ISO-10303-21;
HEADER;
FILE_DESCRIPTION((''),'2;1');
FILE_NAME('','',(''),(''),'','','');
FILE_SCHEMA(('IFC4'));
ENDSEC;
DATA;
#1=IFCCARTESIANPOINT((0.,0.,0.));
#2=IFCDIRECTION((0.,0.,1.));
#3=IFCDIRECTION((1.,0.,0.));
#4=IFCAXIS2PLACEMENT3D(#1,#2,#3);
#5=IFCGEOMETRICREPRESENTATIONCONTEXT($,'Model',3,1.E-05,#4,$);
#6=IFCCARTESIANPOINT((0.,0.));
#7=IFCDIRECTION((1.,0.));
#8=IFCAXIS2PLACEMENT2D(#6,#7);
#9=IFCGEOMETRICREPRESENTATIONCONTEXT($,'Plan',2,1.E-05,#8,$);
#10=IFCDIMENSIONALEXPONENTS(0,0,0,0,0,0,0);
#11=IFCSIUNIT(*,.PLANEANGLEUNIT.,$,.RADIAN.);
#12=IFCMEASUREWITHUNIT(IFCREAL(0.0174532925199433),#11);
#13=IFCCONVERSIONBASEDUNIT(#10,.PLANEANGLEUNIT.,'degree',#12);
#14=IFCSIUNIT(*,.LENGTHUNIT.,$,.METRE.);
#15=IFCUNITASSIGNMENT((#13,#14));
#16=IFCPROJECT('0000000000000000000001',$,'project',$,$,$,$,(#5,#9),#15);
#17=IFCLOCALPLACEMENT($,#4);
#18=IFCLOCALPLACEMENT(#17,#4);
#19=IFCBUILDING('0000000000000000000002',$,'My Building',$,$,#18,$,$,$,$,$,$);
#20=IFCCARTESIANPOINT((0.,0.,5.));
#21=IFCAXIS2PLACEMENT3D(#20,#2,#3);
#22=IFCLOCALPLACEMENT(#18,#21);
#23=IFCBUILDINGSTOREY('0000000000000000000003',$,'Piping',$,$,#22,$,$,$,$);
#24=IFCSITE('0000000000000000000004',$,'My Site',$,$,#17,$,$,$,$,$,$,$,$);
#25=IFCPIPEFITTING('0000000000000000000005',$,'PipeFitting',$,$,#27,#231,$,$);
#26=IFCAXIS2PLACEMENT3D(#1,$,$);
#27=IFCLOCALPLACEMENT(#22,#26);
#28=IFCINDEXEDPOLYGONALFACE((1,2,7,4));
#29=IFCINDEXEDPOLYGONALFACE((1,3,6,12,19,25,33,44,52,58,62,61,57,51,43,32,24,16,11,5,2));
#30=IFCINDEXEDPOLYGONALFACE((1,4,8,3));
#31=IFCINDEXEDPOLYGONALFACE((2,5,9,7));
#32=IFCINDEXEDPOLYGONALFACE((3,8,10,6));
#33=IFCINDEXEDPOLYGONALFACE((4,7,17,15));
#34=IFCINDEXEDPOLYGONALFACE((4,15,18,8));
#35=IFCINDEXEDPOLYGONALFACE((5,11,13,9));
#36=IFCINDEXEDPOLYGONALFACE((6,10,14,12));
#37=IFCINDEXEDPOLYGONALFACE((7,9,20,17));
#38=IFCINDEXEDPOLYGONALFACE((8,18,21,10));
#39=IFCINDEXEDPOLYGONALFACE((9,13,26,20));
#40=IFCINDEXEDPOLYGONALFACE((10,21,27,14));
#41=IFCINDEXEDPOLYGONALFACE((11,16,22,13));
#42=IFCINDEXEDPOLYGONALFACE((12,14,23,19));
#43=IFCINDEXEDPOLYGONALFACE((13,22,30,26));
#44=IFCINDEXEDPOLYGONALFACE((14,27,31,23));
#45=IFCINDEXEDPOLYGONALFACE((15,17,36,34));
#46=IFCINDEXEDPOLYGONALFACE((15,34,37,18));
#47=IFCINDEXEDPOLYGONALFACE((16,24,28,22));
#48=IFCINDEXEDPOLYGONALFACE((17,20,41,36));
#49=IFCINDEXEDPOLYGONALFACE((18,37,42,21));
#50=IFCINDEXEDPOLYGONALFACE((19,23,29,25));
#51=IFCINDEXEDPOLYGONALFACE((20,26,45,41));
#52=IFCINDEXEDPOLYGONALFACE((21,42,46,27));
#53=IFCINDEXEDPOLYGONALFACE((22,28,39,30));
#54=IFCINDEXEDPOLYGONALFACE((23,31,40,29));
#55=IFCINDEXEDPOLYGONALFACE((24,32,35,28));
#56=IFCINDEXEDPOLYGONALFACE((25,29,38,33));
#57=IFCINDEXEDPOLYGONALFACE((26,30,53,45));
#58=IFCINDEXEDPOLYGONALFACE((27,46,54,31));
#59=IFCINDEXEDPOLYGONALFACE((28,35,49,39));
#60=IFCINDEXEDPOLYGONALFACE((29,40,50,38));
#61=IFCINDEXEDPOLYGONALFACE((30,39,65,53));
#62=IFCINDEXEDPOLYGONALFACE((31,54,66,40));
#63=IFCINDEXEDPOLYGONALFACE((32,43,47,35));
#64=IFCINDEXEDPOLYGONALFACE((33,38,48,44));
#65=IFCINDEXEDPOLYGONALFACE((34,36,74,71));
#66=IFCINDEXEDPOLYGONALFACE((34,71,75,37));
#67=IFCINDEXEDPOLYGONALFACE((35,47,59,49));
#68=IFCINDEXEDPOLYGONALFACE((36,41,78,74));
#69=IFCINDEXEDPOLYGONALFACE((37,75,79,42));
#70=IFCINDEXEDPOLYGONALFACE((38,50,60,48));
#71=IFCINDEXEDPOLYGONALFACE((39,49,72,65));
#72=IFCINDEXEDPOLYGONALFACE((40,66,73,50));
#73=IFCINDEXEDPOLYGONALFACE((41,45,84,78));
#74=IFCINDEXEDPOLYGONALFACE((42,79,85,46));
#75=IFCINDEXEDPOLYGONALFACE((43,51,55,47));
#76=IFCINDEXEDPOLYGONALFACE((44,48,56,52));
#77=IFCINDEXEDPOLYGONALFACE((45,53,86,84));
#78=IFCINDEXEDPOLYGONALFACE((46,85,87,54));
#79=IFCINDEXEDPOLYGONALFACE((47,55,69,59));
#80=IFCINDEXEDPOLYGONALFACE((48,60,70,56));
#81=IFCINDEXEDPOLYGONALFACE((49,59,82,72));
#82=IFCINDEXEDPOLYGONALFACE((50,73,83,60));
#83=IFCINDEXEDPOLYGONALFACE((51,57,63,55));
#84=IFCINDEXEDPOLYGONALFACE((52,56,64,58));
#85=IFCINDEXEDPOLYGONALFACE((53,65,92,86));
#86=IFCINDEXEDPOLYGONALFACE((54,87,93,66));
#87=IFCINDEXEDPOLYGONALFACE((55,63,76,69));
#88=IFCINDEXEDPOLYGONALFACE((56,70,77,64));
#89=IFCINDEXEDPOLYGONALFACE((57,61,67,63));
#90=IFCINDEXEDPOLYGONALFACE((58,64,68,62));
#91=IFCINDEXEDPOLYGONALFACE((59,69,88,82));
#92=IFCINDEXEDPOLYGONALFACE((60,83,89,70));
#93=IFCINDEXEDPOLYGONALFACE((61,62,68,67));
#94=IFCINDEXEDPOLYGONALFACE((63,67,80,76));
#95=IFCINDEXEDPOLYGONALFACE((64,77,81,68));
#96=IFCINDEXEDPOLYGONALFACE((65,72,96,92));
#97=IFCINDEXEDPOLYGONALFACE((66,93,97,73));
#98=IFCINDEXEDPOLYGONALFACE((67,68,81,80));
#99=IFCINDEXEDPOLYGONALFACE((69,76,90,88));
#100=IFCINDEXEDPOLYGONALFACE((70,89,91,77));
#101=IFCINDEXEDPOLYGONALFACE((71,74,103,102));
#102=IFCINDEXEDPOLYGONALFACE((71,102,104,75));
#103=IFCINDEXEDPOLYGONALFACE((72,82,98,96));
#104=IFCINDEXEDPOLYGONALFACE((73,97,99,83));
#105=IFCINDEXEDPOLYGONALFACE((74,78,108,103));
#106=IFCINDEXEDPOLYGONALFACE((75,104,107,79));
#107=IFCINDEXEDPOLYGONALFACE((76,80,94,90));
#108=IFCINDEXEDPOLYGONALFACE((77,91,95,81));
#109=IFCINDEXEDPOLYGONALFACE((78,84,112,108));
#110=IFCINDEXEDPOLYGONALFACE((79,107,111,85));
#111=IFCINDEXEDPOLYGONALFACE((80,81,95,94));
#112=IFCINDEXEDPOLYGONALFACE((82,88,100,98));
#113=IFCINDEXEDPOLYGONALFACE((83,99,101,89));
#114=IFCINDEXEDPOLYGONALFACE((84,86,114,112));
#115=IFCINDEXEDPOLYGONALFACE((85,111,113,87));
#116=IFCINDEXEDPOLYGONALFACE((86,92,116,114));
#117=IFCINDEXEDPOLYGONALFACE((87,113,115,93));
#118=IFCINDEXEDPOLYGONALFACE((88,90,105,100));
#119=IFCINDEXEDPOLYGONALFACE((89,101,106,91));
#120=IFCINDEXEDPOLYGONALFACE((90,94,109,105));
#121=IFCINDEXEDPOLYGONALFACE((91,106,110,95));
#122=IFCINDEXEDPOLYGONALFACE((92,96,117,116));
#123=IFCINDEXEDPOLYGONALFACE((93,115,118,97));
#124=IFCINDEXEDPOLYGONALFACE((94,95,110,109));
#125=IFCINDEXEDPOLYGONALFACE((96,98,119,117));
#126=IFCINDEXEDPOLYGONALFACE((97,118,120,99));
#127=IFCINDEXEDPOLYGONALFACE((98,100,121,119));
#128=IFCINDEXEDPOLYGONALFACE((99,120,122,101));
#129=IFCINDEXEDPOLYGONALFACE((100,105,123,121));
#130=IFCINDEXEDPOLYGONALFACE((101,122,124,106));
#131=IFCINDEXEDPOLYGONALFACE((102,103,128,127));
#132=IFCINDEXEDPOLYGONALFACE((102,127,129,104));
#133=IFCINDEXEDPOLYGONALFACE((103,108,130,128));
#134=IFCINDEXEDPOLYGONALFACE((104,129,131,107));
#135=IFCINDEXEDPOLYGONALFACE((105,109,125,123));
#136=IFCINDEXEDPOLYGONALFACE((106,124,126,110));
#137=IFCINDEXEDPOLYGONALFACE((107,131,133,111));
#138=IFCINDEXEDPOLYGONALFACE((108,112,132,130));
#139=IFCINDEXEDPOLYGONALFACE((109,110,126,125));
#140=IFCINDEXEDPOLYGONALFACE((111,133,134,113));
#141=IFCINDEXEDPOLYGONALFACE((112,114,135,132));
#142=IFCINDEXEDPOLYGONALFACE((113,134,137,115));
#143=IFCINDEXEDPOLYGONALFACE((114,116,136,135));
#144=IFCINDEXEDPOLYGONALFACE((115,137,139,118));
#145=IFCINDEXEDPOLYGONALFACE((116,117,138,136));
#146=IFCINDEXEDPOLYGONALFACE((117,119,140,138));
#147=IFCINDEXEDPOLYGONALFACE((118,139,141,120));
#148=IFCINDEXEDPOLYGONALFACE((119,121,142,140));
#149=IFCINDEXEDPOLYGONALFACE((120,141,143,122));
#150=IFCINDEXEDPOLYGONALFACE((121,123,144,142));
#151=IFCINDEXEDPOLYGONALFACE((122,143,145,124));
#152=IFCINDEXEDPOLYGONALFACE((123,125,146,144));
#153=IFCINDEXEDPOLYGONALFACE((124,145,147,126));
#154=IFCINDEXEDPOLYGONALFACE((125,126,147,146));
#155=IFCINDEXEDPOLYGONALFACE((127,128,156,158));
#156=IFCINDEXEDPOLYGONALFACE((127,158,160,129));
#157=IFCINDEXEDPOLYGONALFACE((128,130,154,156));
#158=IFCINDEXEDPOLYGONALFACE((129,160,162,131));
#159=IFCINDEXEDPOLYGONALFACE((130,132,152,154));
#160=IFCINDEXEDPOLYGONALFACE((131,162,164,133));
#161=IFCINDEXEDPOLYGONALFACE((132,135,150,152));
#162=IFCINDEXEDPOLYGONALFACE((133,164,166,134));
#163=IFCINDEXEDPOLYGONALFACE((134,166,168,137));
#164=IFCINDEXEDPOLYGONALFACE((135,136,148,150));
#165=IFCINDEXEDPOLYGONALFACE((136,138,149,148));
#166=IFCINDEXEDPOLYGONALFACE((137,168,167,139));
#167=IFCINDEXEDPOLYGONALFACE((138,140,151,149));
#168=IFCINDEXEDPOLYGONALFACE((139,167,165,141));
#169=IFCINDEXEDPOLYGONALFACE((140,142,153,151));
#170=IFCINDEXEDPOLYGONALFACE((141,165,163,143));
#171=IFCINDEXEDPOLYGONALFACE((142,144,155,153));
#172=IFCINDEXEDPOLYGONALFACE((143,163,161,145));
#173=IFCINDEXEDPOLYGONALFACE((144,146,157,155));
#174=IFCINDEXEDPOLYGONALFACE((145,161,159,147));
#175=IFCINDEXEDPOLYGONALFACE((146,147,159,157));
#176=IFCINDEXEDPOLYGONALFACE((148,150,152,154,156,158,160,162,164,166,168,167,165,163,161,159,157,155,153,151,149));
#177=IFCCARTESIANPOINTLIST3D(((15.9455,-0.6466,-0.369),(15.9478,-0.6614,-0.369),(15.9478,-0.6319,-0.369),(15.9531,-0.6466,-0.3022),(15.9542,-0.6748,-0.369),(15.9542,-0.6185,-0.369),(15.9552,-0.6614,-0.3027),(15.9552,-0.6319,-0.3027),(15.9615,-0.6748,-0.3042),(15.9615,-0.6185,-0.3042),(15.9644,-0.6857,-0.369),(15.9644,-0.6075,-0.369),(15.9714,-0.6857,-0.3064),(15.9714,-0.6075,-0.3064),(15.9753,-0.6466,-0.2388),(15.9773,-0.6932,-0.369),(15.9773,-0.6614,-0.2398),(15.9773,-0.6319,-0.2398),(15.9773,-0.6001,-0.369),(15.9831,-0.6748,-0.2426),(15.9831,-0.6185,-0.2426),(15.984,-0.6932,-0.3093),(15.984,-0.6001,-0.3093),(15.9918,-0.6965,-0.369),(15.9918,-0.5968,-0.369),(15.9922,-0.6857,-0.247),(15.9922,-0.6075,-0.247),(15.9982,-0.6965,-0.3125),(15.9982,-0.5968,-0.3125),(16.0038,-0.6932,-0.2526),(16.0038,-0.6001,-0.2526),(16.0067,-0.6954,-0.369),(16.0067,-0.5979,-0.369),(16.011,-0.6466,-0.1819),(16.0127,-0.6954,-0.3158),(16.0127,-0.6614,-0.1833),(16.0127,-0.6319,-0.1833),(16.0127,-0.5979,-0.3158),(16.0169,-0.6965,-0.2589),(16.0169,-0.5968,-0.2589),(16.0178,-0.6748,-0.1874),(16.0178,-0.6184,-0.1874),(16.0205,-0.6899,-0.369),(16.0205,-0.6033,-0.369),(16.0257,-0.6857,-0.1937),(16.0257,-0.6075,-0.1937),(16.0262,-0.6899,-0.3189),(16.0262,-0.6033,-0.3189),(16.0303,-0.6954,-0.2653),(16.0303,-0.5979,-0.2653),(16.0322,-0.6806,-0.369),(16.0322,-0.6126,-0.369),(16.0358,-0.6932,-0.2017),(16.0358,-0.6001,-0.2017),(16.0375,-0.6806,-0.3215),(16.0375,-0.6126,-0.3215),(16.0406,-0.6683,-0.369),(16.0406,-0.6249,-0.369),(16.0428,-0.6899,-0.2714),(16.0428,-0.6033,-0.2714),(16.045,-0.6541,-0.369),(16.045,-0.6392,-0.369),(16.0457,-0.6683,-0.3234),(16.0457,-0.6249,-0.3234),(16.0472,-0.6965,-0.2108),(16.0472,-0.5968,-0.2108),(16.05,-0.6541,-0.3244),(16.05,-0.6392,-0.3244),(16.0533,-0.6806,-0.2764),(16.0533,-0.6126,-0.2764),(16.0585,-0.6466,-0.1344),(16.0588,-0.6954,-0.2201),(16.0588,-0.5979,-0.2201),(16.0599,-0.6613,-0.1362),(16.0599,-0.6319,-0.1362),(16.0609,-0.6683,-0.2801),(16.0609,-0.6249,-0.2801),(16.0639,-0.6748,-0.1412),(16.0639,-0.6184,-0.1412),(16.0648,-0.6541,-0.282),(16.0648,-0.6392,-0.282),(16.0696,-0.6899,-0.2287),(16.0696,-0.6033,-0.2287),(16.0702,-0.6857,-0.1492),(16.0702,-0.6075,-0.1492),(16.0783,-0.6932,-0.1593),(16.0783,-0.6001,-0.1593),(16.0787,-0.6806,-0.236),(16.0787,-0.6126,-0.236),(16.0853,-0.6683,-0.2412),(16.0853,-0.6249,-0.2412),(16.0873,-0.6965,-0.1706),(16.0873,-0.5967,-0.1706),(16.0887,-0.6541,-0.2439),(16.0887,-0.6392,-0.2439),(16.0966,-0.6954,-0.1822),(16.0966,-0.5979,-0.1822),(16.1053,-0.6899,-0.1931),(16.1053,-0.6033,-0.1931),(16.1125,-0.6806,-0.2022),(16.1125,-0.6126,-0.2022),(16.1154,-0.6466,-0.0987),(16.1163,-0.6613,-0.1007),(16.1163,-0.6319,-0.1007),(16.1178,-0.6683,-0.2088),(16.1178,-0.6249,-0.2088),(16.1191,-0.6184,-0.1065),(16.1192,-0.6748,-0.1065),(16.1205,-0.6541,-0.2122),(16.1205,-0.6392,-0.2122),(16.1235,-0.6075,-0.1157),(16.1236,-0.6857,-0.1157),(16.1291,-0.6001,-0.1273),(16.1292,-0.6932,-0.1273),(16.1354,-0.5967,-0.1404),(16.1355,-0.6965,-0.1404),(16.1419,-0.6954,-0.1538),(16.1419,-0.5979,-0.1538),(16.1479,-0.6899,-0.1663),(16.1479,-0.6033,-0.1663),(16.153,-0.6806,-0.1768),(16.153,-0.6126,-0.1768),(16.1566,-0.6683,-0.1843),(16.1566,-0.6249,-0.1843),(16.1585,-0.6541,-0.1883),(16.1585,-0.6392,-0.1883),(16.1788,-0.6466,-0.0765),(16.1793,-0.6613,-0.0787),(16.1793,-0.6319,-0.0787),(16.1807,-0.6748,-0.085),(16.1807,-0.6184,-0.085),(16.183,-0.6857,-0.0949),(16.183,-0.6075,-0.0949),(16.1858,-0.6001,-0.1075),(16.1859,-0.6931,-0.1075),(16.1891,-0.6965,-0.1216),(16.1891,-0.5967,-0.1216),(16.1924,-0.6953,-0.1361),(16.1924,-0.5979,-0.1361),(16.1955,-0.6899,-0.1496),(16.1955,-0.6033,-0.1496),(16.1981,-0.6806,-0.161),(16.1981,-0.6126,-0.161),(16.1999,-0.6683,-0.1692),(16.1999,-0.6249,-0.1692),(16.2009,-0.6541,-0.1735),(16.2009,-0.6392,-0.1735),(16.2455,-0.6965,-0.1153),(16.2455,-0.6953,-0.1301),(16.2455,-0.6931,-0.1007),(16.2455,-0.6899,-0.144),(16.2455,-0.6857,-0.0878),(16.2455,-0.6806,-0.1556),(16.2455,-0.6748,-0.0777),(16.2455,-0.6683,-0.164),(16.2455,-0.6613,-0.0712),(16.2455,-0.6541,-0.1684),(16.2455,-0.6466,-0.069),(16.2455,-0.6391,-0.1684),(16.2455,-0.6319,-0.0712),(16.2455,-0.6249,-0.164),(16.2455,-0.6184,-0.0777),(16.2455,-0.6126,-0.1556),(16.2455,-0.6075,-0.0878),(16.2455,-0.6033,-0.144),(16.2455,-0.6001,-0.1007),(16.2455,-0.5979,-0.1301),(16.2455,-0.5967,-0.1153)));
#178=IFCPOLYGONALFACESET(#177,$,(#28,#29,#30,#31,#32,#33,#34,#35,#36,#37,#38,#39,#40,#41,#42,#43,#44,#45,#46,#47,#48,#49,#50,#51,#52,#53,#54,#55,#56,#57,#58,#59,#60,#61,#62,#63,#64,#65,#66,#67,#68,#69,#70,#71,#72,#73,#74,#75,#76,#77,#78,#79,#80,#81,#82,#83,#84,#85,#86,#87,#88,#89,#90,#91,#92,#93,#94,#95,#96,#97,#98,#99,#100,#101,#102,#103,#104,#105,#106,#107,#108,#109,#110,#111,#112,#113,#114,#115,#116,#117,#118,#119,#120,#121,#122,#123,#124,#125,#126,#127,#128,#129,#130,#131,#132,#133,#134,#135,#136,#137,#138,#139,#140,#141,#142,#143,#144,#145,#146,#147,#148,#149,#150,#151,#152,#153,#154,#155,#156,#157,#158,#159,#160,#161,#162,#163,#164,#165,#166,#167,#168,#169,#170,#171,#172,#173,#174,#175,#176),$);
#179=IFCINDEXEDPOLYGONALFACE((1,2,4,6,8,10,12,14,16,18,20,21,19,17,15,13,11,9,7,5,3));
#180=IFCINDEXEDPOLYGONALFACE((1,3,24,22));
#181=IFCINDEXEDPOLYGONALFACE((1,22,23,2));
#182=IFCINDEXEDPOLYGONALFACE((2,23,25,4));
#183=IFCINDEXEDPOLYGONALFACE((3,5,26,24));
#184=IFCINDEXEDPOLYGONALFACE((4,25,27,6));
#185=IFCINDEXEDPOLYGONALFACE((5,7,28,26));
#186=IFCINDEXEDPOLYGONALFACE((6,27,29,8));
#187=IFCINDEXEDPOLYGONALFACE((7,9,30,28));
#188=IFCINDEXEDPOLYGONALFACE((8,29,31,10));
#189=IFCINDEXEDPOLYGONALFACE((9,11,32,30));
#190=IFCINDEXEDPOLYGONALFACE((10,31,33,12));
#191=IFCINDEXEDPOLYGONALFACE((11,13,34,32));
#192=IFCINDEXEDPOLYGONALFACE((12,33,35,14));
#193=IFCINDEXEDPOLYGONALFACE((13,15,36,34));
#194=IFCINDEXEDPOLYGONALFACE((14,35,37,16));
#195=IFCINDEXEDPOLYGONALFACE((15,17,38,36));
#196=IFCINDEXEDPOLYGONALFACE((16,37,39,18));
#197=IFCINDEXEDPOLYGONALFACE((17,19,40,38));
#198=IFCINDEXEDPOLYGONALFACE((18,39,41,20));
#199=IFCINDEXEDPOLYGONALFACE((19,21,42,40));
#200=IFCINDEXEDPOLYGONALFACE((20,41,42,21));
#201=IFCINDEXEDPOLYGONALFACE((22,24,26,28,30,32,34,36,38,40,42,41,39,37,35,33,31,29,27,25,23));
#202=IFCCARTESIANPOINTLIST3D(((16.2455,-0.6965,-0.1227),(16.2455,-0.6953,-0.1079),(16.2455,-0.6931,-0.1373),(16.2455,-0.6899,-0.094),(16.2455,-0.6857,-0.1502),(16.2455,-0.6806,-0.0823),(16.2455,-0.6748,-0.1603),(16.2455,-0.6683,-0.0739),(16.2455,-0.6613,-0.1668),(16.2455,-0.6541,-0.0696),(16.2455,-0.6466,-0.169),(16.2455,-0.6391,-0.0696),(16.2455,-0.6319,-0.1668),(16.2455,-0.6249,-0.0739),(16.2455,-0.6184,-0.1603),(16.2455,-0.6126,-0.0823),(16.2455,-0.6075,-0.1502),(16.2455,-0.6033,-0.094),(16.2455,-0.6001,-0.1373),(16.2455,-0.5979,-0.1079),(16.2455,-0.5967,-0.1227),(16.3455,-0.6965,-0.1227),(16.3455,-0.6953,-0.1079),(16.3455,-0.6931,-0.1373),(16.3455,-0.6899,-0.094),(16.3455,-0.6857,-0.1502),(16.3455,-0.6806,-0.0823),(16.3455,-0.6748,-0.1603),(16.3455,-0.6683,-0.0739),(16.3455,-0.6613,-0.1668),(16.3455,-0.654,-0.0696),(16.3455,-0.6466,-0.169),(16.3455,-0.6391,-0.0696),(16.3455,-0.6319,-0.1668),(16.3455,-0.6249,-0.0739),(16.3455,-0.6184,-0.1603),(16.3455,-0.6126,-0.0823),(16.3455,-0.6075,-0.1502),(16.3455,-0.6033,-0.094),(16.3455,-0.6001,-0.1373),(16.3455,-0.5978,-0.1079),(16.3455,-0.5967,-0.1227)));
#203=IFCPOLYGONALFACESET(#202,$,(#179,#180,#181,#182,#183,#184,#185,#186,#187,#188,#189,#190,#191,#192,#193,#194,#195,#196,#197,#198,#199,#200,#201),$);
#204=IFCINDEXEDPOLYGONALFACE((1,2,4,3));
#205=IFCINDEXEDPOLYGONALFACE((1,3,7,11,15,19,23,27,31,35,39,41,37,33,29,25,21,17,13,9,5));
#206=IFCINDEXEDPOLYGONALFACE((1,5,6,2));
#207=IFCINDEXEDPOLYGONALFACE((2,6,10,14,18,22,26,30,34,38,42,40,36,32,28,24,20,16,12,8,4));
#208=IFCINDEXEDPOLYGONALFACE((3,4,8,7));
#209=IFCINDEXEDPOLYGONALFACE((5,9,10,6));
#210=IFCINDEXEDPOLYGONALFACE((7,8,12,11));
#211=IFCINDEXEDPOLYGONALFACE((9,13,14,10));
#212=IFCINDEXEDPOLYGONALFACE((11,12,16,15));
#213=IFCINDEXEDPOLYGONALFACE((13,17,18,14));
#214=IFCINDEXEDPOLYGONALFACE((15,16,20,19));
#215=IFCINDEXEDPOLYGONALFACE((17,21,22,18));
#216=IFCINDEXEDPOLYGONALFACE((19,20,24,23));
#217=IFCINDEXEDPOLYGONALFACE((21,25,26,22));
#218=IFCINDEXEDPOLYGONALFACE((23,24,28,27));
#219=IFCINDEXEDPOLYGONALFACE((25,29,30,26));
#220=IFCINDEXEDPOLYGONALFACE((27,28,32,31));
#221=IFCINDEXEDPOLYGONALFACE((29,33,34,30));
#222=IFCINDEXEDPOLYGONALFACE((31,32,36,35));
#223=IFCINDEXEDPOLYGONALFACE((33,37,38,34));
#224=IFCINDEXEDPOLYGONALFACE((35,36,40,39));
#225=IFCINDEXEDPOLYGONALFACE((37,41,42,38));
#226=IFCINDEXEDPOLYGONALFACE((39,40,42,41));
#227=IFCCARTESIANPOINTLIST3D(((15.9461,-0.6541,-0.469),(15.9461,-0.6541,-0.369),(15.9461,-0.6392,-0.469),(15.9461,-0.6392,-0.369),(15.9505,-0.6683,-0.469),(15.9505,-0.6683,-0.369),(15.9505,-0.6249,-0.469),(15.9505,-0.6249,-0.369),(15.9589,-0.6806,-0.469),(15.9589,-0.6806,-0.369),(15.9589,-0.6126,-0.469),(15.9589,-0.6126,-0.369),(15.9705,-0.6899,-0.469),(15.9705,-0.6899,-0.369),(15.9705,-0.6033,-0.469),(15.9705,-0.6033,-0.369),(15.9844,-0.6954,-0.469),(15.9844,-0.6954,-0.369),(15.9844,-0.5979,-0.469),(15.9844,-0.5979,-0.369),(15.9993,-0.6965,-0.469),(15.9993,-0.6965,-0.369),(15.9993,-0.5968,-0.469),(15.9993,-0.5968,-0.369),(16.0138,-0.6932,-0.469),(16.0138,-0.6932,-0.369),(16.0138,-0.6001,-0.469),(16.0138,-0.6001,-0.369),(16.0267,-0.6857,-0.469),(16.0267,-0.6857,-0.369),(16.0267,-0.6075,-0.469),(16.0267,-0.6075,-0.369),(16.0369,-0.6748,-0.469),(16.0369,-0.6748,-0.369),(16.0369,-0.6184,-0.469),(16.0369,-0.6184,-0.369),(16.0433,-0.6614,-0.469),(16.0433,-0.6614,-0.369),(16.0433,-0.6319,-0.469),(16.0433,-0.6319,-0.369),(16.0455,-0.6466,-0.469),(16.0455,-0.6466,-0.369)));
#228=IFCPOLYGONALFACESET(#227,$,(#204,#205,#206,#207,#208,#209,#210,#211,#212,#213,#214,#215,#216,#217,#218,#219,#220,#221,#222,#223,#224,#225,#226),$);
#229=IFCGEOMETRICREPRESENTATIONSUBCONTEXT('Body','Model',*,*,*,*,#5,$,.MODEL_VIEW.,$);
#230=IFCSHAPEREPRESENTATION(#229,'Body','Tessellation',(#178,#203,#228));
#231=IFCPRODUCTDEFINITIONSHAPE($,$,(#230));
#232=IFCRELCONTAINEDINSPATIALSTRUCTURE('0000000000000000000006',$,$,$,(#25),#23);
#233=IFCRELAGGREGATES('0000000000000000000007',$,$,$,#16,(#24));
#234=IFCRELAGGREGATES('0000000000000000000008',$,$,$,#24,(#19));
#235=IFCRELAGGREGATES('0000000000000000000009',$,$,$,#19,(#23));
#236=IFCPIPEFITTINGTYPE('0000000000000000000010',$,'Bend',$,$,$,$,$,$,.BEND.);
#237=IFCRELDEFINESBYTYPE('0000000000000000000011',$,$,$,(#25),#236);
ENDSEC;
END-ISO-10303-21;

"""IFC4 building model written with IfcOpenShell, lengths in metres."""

from ifc_helpers import new_model, entity, si_unit, converted_unit, frame, origin_with_axes, origin_2d_with_axis, place, context, subcontext, project, spatial, circle, extrude, source, transform, mapped, type_object, type_shapes, element, save


model = new_model("IFC4")

# Units and contexts
model_context = context("Model", 3, precision=1e-05, world=origin_with_axes())
plan_context = context("Plan", 2, precision=1e-05, world=origin_2d_with_axis())
body_context = subcontext(model_context, "Body", "Model", "MODEL_VIEW")
ifc_project = project(units=[converted_unit("PLANEANGLEUNIT", "degree", entity("IfcReal", 0.0174532925199433), si_unit("PLANEANGLEUNIT", "RADIAN"), dimensions=[0, 0, 0, 0, 0, 0, 0]), si_unit("LENGTHUNIT", "METRE")], contexts=[model_context, plan_context])

# Site, building, storey
site_placement = place(None, origin_with_axes())
site = spatial("IfcSite", under=ifc_project, at=site_placement, Name="My Site")
building_placement = place(site_placement, origin_with_axes())
building = spatial("IfcBuilding", under=site, at=building_placement, Name="My Building")
storey_placement = place(building_placement, frame((0.0, 0.0, 5.0), z_axis=(0.0, 0.0, 1.0), x_axis=(1.0, 0.0, 0.0)))
storey = spatial("IfcBuildingStorey", under=building, at=storey_placement, Name="Piping")

# Pipe fitting
pipe_fitting_type_1 = type_object("IfcPipeFittingType", Name="Bend", PredefinedType="BEND")
shared_shape = source(origin_with_axes(), body_context, "Body", "SolidModel", [
    entity("IfcSweptDiskSolid", entity("IfcIndexedPolyCurve", entity("IfcCartesianPointList3D", [[0.0, 0.0, -0.1], [0.0732, 0.0, -0.2768], [0.25, 0.0, -0.35]]), [entity("IfcArcIndex", [1, 2, 3])]), 0.05),
    extrude(circle(Radius=0.05), origin_with_axes(), (0.0, 0.0, -1.0), 0.1),
    extrude(circle(Radius=0.05), frame((0.25, 0.0, -0.35), z_axis=(1.0, 0.0, 0.0), x_axis=(0.0, 0.0, 1.0)), (0.0, 0.0, 1.0), 0.1),
])
type_shapes(pipe_fitting_type_1, [shared_shape])
for number, where, z_axis, x_axis, name in (
    (1, (16.3455, -0.6466, -0.119), (1.0, 0.00006, 0.0), (0.0, 0.0, -1.0), "PipeFitting"),
):
    element("IfcPipeFitting", number, at=place(storey_placement, frame(where, z_axis=z_axis, x_axis=x_axis)), inside=storey, type_object=pipe_fitting_type_1, Name=name, context=body_context, shape_type="MappedRepresentation", body=[
        mapped(shared_shape, transform((0.0, 0.0, 0.0), x_axis=(1.0, 0.0, 0.0), y_axis=(0.0, 1.0, 0.0), z_axis=(0.0, 0.0, 1.0), scale=1.0)),
    ])

save(model, "model.ifc")
